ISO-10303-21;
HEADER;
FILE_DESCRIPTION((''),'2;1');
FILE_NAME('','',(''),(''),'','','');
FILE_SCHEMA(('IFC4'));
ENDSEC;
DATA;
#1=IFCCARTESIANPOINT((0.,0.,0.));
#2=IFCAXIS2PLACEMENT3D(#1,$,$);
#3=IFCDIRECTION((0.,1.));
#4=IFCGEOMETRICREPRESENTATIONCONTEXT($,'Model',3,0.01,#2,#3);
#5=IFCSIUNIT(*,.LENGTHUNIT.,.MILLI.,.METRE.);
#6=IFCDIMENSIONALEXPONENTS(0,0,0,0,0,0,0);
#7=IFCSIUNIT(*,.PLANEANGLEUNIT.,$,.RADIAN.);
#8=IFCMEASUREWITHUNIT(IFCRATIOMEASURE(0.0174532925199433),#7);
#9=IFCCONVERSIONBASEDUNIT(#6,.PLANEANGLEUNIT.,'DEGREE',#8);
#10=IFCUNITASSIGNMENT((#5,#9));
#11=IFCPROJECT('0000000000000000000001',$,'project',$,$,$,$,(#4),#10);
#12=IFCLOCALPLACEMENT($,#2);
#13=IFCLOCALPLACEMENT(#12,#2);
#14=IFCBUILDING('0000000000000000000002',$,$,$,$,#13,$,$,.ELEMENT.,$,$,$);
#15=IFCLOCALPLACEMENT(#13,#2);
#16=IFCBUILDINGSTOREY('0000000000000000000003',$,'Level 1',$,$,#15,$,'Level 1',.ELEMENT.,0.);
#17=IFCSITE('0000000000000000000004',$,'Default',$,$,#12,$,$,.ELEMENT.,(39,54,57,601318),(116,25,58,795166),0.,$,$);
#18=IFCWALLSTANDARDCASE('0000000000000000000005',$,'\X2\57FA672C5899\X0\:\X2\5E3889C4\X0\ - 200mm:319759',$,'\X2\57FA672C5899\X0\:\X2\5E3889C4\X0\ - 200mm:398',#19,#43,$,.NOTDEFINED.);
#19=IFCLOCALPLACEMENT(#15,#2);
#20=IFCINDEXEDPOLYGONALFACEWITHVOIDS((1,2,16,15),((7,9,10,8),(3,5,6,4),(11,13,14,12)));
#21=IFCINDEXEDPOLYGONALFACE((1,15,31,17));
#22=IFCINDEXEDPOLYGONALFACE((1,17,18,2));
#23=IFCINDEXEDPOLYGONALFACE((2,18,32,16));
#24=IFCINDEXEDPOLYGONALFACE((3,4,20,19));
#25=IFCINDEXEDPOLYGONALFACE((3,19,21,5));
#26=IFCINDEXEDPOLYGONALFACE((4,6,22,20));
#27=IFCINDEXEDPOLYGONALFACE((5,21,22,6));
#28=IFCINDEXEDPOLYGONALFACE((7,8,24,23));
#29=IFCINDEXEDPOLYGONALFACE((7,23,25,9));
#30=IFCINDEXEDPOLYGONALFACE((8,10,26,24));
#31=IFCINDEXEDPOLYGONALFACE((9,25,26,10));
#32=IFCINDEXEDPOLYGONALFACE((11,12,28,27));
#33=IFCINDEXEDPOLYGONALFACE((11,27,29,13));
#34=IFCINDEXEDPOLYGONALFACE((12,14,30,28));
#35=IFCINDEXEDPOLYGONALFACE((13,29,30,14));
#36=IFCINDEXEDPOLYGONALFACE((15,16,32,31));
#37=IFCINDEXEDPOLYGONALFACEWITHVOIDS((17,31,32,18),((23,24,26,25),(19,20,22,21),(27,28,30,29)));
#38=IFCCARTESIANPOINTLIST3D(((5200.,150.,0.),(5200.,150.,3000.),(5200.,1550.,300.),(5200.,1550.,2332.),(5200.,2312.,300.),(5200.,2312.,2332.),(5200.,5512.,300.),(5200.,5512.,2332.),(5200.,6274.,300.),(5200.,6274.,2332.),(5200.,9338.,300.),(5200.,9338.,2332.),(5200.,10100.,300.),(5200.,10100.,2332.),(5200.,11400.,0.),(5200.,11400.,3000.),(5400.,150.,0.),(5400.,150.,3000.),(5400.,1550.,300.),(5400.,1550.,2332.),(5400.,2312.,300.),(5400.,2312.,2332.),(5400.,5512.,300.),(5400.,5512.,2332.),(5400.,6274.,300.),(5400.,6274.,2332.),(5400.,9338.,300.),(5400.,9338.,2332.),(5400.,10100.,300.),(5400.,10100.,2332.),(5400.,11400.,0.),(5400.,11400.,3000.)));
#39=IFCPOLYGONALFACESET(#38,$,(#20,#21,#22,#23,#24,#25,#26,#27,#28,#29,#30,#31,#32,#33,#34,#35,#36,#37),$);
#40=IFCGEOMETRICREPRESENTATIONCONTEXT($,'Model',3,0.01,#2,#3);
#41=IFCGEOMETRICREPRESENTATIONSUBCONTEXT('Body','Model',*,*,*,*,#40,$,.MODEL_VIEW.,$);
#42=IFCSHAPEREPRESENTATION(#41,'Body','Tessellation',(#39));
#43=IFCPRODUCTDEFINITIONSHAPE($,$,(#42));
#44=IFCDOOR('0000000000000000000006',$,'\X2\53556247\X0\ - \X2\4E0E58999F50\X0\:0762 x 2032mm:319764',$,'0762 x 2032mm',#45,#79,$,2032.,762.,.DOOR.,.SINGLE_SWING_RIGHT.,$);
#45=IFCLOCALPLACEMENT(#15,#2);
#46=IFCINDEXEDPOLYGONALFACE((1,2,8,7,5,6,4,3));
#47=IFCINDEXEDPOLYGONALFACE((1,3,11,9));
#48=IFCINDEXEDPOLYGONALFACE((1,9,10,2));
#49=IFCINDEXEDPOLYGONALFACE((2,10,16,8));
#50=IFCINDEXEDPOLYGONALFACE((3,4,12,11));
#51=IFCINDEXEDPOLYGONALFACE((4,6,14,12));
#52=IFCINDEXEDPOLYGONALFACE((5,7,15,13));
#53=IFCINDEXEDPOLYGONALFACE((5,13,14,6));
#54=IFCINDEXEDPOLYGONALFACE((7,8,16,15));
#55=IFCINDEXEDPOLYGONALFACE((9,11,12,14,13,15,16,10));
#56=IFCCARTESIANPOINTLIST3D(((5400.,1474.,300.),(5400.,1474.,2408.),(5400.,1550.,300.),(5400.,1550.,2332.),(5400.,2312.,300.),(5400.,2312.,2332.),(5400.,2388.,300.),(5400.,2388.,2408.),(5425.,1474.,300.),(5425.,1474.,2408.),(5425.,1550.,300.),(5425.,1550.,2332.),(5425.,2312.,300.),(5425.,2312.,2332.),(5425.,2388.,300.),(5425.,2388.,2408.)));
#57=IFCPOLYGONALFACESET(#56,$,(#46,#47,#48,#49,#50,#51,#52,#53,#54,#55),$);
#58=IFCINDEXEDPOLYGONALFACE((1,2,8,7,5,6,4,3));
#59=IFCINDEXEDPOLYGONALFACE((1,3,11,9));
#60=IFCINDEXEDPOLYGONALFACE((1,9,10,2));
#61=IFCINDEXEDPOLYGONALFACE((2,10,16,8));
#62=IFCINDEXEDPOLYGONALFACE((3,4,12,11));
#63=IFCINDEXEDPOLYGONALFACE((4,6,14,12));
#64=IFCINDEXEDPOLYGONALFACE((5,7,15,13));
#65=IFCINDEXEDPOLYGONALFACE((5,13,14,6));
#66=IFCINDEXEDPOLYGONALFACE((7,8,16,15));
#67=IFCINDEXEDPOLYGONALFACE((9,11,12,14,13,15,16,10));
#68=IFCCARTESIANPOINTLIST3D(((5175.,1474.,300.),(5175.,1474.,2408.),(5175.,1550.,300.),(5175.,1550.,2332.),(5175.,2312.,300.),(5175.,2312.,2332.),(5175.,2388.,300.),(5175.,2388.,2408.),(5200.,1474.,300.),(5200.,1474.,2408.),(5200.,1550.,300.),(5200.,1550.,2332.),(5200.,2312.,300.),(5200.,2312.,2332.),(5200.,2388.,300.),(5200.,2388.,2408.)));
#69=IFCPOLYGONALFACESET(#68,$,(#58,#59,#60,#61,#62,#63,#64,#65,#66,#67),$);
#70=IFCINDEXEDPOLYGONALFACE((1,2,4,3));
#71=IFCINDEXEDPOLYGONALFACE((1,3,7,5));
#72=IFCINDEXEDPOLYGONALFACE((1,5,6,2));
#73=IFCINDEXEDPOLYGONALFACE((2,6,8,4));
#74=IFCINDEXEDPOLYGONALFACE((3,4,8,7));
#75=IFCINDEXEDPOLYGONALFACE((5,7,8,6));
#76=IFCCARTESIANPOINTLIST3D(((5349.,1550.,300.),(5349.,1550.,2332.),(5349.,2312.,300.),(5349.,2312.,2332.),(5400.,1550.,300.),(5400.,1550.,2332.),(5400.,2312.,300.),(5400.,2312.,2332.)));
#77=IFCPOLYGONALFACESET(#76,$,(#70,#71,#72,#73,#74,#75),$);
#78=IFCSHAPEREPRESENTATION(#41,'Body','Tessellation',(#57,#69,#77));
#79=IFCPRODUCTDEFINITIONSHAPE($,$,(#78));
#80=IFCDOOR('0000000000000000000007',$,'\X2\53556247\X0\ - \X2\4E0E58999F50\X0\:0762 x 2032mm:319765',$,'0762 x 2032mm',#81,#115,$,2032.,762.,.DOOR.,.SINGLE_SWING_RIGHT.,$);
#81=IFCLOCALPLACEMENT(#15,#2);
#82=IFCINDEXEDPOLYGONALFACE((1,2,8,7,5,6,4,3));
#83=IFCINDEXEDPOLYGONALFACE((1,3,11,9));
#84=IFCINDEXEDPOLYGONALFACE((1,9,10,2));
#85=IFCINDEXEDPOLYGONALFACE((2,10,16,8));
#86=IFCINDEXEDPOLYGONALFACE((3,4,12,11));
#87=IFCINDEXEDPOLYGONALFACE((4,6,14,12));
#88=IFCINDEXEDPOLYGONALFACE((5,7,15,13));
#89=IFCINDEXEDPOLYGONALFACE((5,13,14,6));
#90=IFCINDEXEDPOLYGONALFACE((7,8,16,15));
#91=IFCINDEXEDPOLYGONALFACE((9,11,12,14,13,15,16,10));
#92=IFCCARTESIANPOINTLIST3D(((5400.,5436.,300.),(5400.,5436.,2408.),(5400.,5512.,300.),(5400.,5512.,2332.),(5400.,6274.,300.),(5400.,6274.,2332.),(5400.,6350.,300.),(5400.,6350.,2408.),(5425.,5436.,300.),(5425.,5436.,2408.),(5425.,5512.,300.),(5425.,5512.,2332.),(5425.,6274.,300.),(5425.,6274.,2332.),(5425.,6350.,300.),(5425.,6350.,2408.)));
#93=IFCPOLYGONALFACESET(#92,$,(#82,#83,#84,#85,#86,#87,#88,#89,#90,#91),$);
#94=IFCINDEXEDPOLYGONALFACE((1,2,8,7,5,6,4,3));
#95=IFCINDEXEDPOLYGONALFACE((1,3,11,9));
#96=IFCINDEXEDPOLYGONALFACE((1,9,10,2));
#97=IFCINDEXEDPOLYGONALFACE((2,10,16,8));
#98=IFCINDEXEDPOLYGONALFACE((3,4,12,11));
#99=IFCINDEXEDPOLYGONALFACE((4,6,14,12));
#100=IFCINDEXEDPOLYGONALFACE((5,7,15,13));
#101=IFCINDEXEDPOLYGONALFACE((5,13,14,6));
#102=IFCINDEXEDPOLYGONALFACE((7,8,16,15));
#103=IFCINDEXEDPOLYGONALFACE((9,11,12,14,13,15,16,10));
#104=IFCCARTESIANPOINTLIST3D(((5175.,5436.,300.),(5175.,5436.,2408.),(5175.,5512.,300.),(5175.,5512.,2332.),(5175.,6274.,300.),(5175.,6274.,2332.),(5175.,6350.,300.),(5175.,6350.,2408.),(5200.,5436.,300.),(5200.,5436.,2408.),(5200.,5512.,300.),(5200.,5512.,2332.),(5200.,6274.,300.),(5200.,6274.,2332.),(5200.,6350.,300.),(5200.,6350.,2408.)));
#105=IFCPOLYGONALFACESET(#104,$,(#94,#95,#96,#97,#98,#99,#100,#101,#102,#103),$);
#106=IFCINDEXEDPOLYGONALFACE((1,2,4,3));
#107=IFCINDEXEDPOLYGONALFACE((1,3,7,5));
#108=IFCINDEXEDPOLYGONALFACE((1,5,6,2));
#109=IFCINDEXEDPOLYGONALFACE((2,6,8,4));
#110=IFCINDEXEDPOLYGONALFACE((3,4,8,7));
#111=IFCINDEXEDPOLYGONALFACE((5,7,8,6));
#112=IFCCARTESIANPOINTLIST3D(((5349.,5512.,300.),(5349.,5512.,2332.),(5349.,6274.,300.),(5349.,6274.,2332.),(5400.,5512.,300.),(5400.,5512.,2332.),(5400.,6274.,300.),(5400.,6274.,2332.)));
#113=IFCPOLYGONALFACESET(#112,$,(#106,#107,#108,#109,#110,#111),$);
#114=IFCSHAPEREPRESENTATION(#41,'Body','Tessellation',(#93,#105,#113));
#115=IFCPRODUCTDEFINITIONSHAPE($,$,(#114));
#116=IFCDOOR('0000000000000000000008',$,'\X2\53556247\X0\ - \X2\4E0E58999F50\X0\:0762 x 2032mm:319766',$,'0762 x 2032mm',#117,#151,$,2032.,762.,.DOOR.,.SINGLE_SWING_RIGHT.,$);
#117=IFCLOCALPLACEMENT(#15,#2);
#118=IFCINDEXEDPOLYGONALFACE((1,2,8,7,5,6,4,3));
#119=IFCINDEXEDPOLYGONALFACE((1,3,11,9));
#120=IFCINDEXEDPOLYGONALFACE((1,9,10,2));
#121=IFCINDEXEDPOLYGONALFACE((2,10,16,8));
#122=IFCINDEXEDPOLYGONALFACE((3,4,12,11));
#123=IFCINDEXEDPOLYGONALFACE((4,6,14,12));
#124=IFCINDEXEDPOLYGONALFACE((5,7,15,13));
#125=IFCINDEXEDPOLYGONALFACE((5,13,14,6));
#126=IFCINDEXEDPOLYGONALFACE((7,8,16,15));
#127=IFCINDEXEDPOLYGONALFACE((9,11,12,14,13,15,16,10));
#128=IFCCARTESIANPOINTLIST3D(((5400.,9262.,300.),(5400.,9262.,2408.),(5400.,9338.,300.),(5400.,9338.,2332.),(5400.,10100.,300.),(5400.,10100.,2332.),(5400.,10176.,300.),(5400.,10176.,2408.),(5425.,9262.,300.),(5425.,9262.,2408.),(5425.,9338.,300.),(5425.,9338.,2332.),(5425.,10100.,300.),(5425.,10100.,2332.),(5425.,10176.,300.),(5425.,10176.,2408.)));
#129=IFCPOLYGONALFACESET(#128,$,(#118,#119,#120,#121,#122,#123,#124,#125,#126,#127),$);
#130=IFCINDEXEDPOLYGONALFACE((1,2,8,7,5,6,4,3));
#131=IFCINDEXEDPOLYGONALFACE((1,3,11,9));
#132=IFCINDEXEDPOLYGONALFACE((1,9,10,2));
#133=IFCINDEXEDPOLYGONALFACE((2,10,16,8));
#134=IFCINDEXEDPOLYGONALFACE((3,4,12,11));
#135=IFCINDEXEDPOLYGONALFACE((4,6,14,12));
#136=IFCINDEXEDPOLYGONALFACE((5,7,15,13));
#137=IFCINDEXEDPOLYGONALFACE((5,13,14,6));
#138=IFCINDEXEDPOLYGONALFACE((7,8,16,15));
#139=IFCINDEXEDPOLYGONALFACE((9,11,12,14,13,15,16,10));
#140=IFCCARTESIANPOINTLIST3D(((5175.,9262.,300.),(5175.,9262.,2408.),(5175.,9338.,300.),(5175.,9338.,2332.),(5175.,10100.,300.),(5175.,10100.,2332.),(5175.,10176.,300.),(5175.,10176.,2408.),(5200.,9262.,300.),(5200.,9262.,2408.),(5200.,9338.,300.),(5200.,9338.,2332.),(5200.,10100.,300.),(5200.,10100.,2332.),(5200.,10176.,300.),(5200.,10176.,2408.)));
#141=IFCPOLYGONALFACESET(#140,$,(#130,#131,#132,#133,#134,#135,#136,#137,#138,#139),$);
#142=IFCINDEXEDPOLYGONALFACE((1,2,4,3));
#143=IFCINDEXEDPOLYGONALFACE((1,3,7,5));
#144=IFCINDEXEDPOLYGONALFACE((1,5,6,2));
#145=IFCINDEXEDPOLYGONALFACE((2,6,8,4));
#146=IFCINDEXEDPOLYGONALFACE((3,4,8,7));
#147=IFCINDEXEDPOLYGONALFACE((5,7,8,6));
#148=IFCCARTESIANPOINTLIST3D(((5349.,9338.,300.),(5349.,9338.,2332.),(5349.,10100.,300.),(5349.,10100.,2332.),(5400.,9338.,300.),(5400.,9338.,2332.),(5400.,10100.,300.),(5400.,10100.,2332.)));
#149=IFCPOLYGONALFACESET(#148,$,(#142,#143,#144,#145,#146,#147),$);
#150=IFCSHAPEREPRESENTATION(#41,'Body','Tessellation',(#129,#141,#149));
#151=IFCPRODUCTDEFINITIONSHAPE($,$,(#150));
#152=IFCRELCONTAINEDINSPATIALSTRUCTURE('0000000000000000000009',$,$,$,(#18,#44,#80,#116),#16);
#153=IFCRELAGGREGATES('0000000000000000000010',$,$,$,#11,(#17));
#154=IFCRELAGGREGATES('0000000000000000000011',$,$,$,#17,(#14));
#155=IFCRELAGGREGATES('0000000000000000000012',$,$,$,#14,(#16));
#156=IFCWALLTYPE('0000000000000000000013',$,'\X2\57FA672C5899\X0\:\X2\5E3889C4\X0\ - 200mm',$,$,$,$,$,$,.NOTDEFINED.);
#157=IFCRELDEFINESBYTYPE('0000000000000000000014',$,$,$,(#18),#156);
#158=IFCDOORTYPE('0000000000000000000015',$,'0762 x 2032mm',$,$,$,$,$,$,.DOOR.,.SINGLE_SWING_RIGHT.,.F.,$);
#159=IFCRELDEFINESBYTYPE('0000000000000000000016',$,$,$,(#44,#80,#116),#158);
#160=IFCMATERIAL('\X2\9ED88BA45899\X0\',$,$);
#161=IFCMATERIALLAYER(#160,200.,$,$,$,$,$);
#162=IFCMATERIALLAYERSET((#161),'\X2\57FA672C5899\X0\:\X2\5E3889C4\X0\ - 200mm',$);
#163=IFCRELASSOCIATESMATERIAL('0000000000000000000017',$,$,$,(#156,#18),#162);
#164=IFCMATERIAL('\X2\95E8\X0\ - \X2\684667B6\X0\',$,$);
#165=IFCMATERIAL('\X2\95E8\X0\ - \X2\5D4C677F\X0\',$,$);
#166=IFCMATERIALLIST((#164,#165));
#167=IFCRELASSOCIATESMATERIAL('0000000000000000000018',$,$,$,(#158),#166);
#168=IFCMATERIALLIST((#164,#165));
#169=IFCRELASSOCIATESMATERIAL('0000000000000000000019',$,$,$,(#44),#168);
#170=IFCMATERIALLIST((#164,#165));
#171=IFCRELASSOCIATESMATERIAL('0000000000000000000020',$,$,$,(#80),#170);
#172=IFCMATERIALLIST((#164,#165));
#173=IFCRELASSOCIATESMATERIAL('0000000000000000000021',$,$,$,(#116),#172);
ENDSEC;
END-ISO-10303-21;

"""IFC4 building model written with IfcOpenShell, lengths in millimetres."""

from ifc_helpers import new_model, entity, si_unit, converted_unit, direction, frame, frame_2d, origin, origin_2d_with_axis, place, context, subcontext, project, spatial, polyline, rectangle, outline, extrude, source, transform, mapped, material, material_list, layer, layer_set, layer_usage, type_object, type_shapes, element, fill, save


model = new_model("IFC4")

# Units and contexts
model_context_1 = context("Model", 3, precision=0.01, world=origin(), true_north=direction((0.0, 1.0)))
model_context_2 = context("Model", 3, precision=0.01, world=origin(), true_north=direction((0.0, 1.0)))
body_context_1 = subcontext(model_context_2, "Body", "Model", "MODEL_VIEW")
ifc_project = project(units=[si_unit("LENGTHUNIT", "METRE", prefix="MILLI"), converted_unit("PLANEANGLEUNIT", "DEGREE", entity("IfcRatioMeasure", 0.0174532925199433), si_unit("PLANEANGLEUNIT", "RADIAN"), dimensions=[0, 0, 0, 0, 0, 0, 0])], contexts=[model_context_1])

# Site, building, storey
site_placement = place(None, origin())
site = spatial("IfcSite", under=ifc_project, at=site_placement, Name="Default", CompositionType="ELEMENT", RefLatitude=(39, 54, 57, 601318), RefLongitude=(116, 25, 58, 795166), RefElevation=0.0)
building_placement = place(site_placement, origin())
building = spatial("IfcBuilding", under=site, at=building_placement, CompositionType="ELEMENT")
storey_placement = place(building_placement, origin())
storey = spatial("IfcBuildingStorey", under=building, at=storey_placement, Name="Level 1", LongName="Level 1", CompositionType="ELEMENT", Elevation=0.0)

# Shared definitions
placement_1 = place(None, origin())
placement_2 = place(placement_1, origin())
placement_3 = place(placement_2, origin())

# Wall, openings, doors
ifc_material_1 = material(Name="默认墙")
ifc_layer_1 = layer(ifc_material_1, 200.0)
ifc_layer_set_1 = layer_set([ifc_layer_1], Name="基本墙:常规 - 200mm")
ifc_layer_usage_1 = layer_usage(ifc_layer_set_1, "AXIS2", "NEGATIVE", 100.0)
wall_type_1 = type_object("IfcWallType", Name="基本墙:常规 - 200mm", PredefinedType="NOTDEFINED", material=ifc_layer_set_1)
wall_1_placement = place(placement_3, frame((5300.0, 11400.0, 0.0), z_axis=(0.0, 0.0, 1.0), x_axis=(0.0, -1.0, 0.0)))
wall_1 = element("IfcWallStandardCase", 1, at=wall_1_placement, inside=storey, type_object=wall_type_1, material=ifc_layer_usage_1, Name="基本墙:常规 - 200mm:319759", ObjectType="基本墙:常规 - 200mm:398", PredefinedType="NOTDEFINED", context=body_context_1, shape_type="SweptSolid", body=[
    extrude(rectangle(XDim=11250.0, YDim=200.0, at=frame_2d((5625.0, 0.0), x_axis=(-1.0, 0.0))), origin(), (0.0, 0.0, 1.0), 3000.0),
])
opening_1_placement = place(wall_1_placement, frame((9088.0, -100.0, 300.0)))
opening_1 = element("IfcOpeningElement", 2, at=opening_1_placement, cuts=wall_1, ObjectType="Opening", PredefinedType="OPENING", context=body_context_1, shape_type="SweptSolid", body=[
    extrude(rectangle(XDim=762.0, YDim=2032.0, at=frame_2d((1016.0, 381.0), x_axis=(0.0, 1.0))), frame((0.0, 0.0, 0.0), z_axis=(0.0, 1.0, 0.0), x_axis=(0.0, 0.0, 1.0)), (0.0, 0.0, 1.0), 200.0),
])
opening_2_placement = place(wall_1_placement, frame((5126.0, -100.0, 300.0)))
opening_2 = element("IfcOpeningElement", 3, at=opening_2_placement, cuts=wall_1, ObjectType="Opening", PredefinedType="OPENING", context=body_context_1, shape_type="SweptSolid", body=[
    extrude(rectangle(XDim=762.0, YDim=2032.0, at=frame_2d((1016.0, 381.0), x_axis=(0.0, 1.0))), frame((0.0, 0.0, 0.0), z_axis=(0.0, 1.0, 0.0), x_axis=(0.0, 0.0, 1.0)), (0.0, 0.0, 1.0), 200.0),
])
opening_3_placement = place(wall_1_placement, frame((1300.0, -100.0, 300.0)))
opening_3 = element("IfcOpeningElement", 4, at=opening_3_placement, cuts=wall_1, ObjectType="Opening", PredefinedType="OPENING", context=body_context_1, shape_type="SweptSolid", body=[
    extrude(rectangle(XDim=762.0, YDim=2032.0, at=frame_2d((1016.0, 381.0), x_axis=(0.0, 1.0))), frame((0.0, 0.0, 0.0), z_axis=(0.0, 1.0, 0.0), x_axis=(0.0, 0.0, 1.0)), (0.0, 0.0, 1.0), 200.0),
])
ifc_material_2 = material(Name="门 - 框架")
ifc_material_3 = material(Name="门 - 嵌板")
ifc_material_list_1 = material_list([ifc_material_2, ifc_material_3])
ifc_material_list_2 = material_list([ifc_material_2, ifc_material_3])
door_type_1 = type_object("IfcDoorType", Name="0762 x 2032mm", OperationType="SINGLE_SWING_RIGHT", ParameterTakesPrecedence=False, PredefinedType="DOOR", material=ifc_material_list_2)
shared_shape_1 = source(origin(), body_context_1, "Body", "SweptSolid", [
    extrude(outline(polyline([(-457.0, -1073.0), (457.0, -1073.0), (457.0, 1035.0), (381.0, 1035.0), (381.0, -997.0), (-381.0, -997.0), (-381.0, 1035.0), (-457.0, 1035.0), (-457.0, -1073.0)])), frame((381.0, 200.0, 1035.0), z_axis=(0.0, 1.0, 0.0), x_axis=(1.0, 0.0, 0.0)), (0.0, 0.0, 1.0), 25.0),
    extrude(outline(polyline([(-1073.0, -457.0), (1035.0, -457.0), (1035.0, -381.0), (-997.0, -381.0), (-997.0, 381.0), (1035.0, 381.0), (1035.0, 457.0), (-1073.0, 457.0), (-1073.0, -457.0)])), frame((381.0, -25.0, 1035.0), z_axis=(0.0, 1.0, 0.0), x_axis=(0.0, 0.0, -1.0)), (0.0, 0.0, 1.0), 25.0),
    extrude(rectangle(XDim=51.0, YDim=762.0, at=origin_2d_with_axis()), frame((381.0, 174.5, 0.0), z_axis=(0.0, 0.0, 1.0), x_axis=(0.0, 1.0, 0.0)), (0.0, 0.0, 1.0), 2032.0),
])
type_shapes(door_type_1, [shared_shape_1])
door_1_placement = place(opening_1_placement, origin())
door_1 = element("IfcDoor", 5, at=door_1_placement, inside=storey, type_object=door_type_1, material=ifc_material_list_1, Name="单扇 - 与墙齐:0762 x 2032mm:319764", ObjectType="0762 x 2032mm", OperationType="SINGLE_SWING_RIGHT", OverallHeight=2032.0, OverallWidth=762.0, PredefinedType="DOOR", context=body_context_1, shape_type="MappedRepresentation", body=[
    mapped(shared_shape_1, transform((0.0, 0.0, 0.0), scale=1.0)),
])
fill(opening_1, door_1)
ifc_material_list_3 = material_list([ifc_material_2, ifc_material_3])
door_2_placement = place(opening_2_placement, origin())
door_2 = element("IfcDoor", 6, at=door_2_placement, inside=storey, type_object=door_type_1, material=ifc_material_list_3, Name="单扇 - 与墙齐:0762 x 2032mm:319765", ObjectType="0762 x 2032mm", OperationType="SINGLE_SWING_RIGHT", OverallHeight=2032.0, OverallWidth=762.0, PredefinedType="DOOR", context=body_context_1, shape_type="MappedRepresentation", body=[
    mapped(shared_shape_1, transform((0.0, 0.0, 0.0), scale=1.0)),
])
fill(opening_2, door_2)
ifc_material_list_4 = material_list([ifc_material_2, ifc_material_3])
door_3_placement = place(opening_3_placement, origin())
door_3 = element("IfcDoor", 7, at=door_3_placement, inside=storey, type_object=door_type_1, material=ifc_material_list_4, Name="单扇 - 与墙齐:0762 x 2032mm:319766", ObjectType="0762 x 2032mm", OperationType="SINGLE_SWING_RIGHT", OverallHeight=2032.0, OverallWidth=762.0, PredefinedType="DOOR", context=body_context_1, shape_type="MappedRepresentation", body=[
    mapped(shared_shape_1, transform((0.0, 0.0, 0.0), scale=1.0)),
])
fill(opening_3, door_3)

save(model, "model.ifc")
